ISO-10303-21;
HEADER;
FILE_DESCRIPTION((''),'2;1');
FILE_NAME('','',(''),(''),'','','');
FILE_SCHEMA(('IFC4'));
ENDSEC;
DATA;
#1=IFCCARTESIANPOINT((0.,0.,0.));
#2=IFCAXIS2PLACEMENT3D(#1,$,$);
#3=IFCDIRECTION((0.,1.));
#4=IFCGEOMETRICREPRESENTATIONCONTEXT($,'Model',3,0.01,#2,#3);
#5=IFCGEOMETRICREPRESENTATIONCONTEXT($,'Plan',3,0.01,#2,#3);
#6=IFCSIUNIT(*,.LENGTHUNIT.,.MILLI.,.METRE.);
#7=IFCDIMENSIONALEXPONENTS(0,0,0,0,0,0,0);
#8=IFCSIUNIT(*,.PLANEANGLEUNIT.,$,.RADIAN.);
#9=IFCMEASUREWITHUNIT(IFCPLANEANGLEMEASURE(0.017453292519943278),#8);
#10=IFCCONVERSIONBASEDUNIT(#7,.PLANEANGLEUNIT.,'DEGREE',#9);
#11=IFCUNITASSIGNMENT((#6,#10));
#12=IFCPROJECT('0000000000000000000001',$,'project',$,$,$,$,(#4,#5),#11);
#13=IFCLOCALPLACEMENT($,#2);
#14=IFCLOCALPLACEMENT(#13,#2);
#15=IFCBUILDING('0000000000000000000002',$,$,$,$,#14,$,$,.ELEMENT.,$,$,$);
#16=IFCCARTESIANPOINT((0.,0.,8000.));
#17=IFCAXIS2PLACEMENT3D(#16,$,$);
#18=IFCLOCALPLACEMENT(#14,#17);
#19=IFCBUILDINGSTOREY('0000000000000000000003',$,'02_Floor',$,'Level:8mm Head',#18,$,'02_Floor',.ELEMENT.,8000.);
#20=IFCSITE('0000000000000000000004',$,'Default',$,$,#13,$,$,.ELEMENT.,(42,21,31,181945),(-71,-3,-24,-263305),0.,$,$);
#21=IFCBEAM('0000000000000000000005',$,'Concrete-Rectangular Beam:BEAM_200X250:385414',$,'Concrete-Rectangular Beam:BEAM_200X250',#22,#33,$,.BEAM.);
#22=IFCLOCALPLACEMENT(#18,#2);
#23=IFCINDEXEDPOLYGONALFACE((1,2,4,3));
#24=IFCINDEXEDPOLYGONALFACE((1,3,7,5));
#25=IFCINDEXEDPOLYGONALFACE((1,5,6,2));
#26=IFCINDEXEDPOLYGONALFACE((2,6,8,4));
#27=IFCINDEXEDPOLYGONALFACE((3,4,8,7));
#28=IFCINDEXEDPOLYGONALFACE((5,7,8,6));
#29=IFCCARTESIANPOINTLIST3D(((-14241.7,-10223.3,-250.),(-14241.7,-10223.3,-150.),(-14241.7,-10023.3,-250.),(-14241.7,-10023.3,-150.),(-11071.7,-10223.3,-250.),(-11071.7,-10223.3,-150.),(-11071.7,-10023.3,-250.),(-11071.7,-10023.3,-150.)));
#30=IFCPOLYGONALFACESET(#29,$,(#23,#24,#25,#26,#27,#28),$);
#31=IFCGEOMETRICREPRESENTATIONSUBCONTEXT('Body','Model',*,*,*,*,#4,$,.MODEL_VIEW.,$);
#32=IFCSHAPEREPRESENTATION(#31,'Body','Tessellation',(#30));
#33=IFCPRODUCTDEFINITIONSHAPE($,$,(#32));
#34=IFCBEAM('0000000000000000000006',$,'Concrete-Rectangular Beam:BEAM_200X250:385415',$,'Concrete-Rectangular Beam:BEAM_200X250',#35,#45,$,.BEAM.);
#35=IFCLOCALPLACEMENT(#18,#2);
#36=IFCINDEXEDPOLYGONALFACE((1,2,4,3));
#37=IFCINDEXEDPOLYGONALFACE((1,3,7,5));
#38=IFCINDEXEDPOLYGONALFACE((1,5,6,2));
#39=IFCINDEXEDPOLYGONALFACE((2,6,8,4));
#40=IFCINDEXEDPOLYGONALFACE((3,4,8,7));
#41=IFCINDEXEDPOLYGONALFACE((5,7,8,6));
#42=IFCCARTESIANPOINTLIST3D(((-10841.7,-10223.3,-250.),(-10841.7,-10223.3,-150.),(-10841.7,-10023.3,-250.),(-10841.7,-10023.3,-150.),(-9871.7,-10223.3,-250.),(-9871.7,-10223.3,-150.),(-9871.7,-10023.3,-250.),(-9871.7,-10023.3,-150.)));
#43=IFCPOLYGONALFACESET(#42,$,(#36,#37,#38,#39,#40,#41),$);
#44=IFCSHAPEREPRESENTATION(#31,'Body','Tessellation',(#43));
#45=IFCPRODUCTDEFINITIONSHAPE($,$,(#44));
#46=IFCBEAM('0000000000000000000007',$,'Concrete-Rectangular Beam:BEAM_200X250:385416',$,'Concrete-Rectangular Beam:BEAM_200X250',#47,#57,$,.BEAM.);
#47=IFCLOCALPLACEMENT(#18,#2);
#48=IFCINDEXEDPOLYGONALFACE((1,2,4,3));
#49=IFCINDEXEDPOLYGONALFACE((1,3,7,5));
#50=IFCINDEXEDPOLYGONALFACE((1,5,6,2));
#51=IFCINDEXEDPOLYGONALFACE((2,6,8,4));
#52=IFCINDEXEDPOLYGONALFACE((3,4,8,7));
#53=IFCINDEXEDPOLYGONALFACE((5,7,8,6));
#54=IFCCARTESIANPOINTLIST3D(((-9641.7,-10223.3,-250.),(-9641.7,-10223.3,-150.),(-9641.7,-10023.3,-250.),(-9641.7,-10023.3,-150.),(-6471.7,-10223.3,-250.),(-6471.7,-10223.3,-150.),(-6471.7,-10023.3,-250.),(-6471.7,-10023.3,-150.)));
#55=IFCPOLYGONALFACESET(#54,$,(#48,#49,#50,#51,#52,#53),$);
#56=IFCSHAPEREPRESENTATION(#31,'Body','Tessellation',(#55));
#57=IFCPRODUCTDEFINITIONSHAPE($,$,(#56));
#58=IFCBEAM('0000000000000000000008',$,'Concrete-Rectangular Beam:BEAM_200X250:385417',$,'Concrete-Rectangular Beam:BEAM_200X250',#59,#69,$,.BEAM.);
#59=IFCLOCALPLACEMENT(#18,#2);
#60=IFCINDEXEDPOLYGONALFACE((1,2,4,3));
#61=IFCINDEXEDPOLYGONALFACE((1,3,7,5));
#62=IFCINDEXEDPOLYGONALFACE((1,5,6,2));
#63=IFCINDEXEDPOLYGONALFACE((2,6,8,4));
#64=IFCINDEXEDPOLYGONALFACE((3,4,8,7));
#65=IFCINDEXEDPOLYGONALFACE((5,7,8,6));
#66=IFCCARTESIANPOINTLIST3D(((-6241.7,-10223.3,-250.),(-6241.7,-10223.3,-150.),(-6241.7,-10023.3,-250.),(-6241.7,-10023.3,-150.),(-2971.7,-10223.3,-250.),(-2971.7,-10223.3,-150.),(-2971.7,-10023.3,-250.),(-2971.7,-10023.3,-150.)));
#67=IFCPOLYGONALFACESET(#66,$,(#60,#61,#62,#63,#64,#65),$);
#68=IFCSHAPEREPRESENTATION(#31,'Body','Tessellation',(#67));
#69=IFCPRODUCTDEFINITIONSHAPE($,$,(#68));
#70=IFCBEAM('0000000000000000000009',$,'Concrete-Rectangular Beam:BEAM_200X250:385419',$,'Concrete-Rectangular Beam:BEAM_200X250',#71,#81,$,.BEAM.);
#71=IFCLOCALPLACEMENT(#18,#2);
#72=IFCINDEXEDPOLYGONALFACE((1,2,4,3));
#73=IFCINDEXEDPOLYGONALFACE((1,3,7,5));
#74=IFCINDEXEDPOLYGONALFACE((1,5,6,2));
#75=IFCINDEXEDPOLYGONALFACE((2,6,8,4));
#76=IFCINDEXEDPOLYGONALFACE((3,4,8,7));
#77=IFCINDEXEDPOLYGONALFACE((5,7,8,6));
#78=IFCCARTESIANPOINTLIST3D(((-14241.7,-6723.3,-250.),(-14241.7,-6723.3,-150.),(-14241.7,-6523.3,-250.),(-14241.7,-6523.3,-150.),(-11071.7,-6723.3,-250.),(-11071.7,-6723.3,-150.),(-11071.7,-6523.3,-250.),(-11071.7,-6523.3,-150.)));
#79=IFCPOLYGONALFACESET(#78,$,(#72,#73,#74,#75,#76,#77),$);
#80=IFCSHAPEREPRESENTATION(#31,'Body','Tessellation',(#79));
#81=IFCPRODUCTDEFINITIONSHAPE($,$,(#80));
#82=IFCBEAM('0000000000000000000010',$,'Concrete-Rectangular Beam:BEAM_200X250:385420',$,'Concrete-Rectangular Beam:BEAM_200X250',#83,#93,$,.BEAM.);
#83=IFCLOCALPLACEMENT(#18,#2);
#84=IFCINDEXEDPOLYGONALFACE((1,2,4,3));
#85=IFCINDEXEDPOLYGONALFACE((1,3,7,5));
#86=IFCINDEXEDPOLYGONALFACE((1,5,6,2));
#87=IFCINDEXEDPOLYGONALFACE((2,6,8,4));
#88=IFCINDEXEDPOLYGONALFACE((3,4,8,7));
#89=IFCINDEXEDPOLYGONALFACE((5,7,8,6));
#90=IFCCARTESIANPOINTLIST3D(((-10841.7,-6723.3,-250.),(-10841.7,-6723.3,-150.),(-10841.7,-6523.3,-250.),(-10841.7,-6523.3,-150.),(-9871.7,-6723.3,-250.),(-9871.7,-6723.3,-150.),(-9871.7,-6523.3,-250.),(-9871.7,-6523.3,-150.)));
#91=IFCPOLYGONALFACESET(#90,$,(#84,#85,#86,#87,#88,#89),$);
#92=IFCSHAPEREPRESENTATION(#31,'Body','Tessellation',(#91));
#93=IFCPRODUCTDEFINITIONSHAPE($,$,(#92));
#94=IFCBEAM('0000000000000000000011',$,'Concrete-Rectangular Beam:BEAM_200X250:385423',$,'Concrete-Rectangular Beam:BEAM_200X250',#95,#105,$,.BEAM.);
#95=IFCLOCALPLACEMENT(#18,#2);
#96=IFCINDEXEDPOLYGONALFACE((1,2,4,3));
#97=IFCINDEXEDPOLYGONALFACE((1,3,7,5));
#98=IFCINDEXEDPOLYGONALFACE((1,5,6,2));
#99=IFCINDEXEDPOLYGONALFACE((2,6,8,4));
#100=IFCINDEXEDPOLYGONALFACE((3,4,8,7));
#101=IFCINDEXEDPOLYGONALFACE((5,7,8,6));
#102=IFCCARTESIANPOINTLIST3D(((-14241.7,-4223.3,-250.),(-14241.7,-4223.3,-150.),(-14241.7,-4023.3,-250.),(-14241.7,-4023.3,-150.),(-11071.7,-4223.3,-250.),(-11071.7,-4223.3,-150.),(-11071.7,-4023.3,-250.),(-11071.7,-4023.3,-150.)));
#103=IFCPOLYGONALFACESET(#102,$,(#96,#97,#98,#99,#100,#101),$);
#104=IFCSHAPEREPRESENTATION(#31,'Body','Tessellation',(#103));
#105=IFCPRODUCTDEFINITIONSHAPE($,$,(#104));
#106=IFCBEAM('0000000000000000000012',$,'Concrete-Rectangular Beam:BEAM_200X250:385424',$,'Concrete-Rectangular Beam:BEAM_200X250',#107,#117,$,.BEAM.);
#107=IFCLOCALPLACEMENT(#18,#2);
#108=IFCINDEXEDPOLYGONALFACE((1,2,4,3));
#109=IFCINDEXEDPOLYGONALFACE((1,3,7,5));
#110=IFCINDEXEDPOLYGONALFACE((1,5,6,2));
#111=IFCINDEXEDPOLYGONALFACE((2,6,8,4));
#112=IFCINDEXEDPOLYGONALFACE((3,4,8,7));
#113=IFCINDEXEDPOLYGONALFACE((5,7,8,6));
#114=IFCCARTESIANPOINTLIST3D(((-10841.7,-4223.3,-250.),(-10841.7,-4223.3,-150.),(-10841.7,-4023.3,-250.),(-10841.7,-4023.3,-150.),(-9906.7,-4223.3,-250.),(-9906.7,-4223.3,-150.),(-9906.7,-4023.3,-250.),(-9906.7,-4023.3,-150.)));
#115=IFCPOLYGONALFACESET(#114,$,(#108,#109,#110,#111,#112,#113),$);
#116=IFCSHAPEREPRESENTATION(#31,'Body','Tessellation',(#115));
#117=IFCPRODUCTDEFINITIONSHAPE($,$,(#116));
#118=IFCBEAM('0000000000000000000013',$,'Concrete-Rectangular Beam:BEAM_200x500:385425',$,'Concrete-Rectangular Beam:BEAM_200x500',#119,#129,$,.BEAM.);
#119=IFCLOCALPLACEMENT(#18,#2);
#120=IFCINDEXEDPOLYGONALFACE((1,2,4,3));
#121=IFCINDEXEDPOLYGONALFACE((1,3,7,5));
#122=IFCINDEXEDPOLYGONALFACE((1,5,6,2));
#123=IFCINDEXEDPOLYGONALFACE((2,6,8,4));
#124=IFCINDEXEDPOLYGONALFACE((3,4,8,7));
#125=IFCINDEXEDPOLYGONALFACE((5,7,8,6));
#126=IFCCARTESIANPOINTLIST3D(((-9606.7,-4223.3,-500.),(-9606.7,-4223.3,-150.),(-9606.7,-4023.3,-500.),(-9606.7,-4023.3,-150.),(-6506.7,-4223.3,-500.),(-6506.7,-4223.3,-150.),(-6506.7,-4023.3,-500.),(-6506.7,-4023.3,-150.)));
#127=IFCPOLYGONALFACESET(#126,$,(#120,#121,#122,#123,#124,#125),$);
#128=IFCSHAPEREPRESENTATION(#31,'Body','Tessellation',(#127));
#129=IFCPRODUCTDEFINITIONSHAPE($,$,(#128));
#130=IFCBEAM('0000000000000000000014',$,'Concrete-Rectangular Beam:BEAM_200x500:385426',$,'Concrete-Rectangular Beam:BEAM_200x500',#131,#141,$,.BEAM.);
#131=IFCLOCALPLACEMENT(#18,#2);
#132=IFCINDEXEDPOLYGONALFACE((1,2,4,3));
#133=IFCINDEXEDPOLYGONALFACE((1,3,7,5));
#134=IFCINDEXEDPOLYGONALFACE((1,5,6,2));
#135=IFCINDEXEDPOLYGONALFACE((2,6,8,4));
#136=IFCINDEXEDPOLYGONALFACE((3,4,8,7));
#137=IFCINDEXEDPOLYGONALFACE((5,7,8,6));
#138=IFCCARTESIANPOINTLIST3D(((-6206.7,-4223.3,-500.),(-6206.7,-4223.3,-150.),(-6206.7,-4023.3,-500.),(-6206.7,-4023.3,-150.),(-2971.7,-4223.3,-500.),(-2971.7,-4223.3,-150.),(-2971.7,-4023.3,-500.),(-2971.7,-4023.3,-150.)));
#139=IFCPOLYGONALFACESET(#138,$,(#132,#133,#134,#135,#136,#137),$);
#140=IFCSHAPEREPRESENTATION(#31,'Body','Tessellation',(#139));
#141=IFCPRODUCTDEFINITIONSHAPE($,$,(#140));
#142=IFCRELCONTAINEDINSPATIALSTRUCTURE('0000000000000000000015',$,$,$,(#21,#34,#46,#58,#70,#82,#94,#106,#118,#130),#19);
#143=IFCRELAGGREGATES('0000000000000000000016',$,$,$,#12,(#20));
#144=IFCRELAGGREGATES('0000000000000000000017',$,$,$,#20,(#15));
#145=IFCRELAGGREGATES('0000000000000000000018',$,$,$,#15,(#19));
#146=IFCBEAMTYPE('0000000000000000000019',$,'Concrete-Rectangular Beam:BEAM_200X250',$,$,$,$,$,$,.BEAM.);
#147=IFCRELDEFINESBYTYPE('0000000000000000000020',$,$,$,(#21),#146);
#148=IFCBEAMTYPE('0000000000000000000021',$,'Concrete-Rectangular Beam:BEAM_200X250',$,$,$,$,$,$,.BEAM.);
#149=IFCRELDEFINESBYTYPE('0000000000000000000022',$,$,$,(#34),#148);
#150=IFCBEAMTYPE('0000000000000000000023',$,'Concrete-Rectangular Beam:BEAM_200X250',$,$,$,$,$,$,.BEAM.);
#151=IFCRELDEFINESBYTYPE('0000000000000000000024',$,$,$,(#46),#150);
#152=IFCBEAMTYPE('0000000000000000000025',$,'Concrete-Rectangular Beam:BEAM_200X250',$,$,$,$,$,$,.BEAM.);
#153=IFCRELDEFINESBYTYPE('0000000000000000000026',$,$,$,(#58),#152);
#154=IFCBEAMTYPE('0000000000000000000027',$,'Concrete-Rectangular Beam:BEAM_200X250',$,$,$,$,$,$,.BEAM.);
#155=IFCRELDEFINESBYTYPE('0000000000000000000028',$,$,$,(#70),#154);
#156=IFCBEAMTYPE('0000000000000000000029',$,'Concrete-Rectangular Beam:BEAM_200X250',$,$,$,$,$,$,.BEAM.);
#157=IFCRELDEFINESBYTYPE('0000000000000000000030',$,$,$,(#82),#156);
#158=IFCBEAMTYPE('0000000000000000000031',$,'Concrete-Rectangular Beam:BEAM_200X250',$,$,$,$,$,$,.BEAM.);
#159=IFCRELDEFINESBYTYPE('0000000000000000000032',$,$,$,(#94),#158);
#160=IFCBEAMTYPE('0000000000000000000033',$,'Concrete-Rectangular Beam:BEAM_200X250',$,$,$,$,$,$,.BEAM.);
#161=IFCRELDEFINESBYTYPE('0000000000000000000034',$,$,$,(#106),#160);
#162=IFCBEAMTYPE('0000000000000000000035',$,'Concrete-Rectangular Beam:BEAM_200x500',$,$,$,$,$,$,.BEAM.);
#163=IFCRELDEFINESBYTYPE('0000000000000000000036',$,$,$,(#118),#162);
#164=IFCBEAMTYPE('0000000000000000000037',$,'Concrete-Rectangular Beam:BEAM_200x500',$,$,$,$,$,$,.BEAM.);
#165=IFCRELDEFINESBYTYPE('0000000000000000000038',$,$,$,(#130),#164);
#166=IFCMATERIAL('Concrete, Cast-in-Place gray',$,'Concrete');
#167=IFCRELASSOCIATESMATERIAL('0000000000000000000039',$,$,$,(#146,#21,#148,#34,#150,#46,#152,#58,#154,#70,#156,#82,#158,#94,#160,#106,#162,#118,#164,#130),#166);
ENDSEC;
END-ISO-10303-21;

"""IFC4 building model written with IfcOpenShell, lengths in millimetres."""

from ifc_helpers import new_model, entity, si_unit, converted_unit, direction, frame, origin, place, context, subcontext, project, spatial, indexed_curve, outline, extrude, source, transform, mapped, material, type_object, type_shapes, element, save


model = new_model("IFC4")

# Units and contexts
model_context = context("Model", 3, precision=0.01, world=origin(), true_north=direction((0.0, 1.0)))
plan_context = context("Plan", 3, precision=0.01, world=origin(), true_north=direction((0.0, 1.0)))
body_context = subcontext(model_context, "Body", "Model", "MODEL_VIEW")
ifc_project = project(units=[si_unit("LENGTHUNIT", "METRE", prefix="MILLI"), converted_unit("PLANEANGLEUNIT", "DEGREE", entity("IfcPlaneAngleMeasure", 0.017453292519943278), si_unit("PLANEANGLEUNIT", "RADIAN"), dimensions=[0, 0, 0, 0, 0, 0, 0])], contexts=[model_context, plan_context])

# Site, building, storey
site_placement = place(None, origin())
site = spatial("IfcSite", under=ifc_project, at=site_placement, Name="Default", CompositionType="ELEMENT", RefLatitude=(42, 21, 31, 181945), RefLongitude=(-71, -3, -24, -263305), RefElevation=0.0)
building_placement = place(site_placement, origin())
building = spatial("IfcBuilding", under=site, at=building_placement, CompositionType="ELEMENT")
storey_placement = place(building_placement, frame((0.0, 0.0, 8000.0)))
storey = spatial("IfcBuildingStorey", under=building, at=storey_placement, Name="02_Floor", ObjectType="Level:8mm Head", LongName="02_Floor", CompositionType="ELEMENT", Elevation=8000.0)

# Beams
ifc_material_1 = material(Name="Concrete, Cast-in-Place gray", Category="Concrete")
beam_type_1 = type_object("IfcBeamType", Name="Concrete-Rectangular Beam:BEAM_200X250", PredefinedType="BEAM", material=ifc_material_1)
shared_shape_1 = source(origin(), body_context, "Body", "SweptSolid", [
    extrude(outline(indexed_curve([(-50.0, -100.0), (50.0, -100.0), (50.0, 100.0), (-50.0, 100.0), (-50.0, -100.0)], self_intersect=False)), frame((-14241.7, -10123.3, 7800.0), z_axis=(1.0, 0.0, 0.0), x_axis=(0.0, 0.0, -1.0)), (0.0, 0.0, 1.0), 3170.0),
])
type_shapes(beam_type_1, [shared_shape_1])
beam_1_placement = place(storey_placement, frame((0.0, 0.0, -8000.0)))
element("IfcBeam", 1, at=beam_1_placement, inside=storey, type_object=beam_type_1, material=ifc_material_1, Name="Concrete-Rectangular Beam:BEAM_200X250:385414", ObjectType="Concrete-Rectangular Beam:BEAM_200X250", PredefinedType="BEAM", context=body_context, shape_type="MappedRepresentation", body=[
    mapped(shared_shape_1, transform((0.0, 0.0, 0.0), scale=1.0)),
])
beam_type_2 = type_object("IfcBeamType", Name="Concrete-Rectangular Beam:BEAM_200X250", PredefinedType="BEAM", material=ifc_material_1)
shared_shape_2 = source(origin(), body_context, "Body", "SweptSolid", [
    extrude(outline(indexed_curve([(-50.0, -100.0), (50.0, -100.0), (50.0, 100.0), (-50.0, 100.0), (-50.0, -100.0)], self_intersect=False)), frame((-10841.7, -10123.3, 7800.0), z_axis=(1.0, 0.0, 0.0), x_axis=(0.0, 0.0, -1.0)), (0.0, 0.0, 1.0), 970.0),
])
type_shapes(beam_type_2, [shared_shape_2])
beam_2_placement = place(storey_placement, frame((0.0, 0.0, -8000.0)))
element("IfcBeam", 2, at=beam_2_placement, inside=storey, type_object=beam_type_2, material=ifc_material_1, Name="Concrete-Rectangular Beam:BEAM_200X250:385415", ObjectType="Concrete-Rectangular Beam:BEAM_200X250", PredefinedType="BEAM", context=body_context, shape_type="MappedRepresentation", body=[
    mapped(shared_shape_2, transform((0.0, 0.0, 0.0), scale=1.0)),
])
beam_type_3 = type_object("IfcBeamType", Name="Concrete-Rectangular Beam:BEAM_200X250", PredefinedType="BEAM", material=ifc_material_1)
shared_shape_3 = source(origin(), body_context, "Body", "SweptSolid", [
    extrude(outline(indexed_curve([(-50.0, -100.0), (50.0, -100.0), (50.0, 100.0), (-50.0, 100.0), (-50.0, -100.0)], self_intersect=False)), frame((-9641.7, -10123.3, 7800.0), z_axis=(1.0, 0.0, 0.0), x_axis=(0.0, 0.0, -1.0)), (0.0, 0.0, 1.0), 3170.0),
])
type_shapes(beam_type_3, [shared_shape_3])
beam_3_placement = place(storey_placement, frame((0.0, 0.0, -8000.0)))
element("IfcBeam", 3, at=beam_3_placement, inside=storey, type_object=beam_type_3, material=ifc_material_1, Name="Concrete-Rectangular Beam:BEAM_200X250:385416", ObjectType="Concrete-Rectangular Beam:BEAM_200X250", PredefinedType="BEAM", context=body_context, shape_type="MappedRepresentation", body=[
    mapped(shared_shape_3, transform((0.0, 0.0, 0.0), scale=1.0)),
])
beam_type_4 = type_object("IfcBeamType", Name="Concrete-Rectangular Beam:BEAM_200X250", PredefinedType="BEAM", material=ifc_material_1)
shared_shape_4 = source(origin(), body_context, "Body", "SweptSolid", [
    extrude(outline(indexed_curve([(-50.0, -100.0), (50.0, -100.0), (50.0, 100.0), (-50.0, 100.0), (-50.0, -100.0)], self_intersect=False)), frame((-6241.7, -10123.3, 7800.0), z_axis=(1.0, 0.0, 0.0), x_axis=(0.0, 0.0, -1.0)), (0.0, 0.0, 1.0), 3270.0),
])
type_shapes(beam_type_4, [shared_shape_4])
beam_4_placement = place(storey_placement, frame((0.0, 0.0, -8000.0)))
element("IfcBeam", 4, at=beam_4_placement, inside=storey, type_object=beam_type_4, material=ifc_material_1, Name="Concrete-Rectangular Beam:BEAM_200X250:385417", ObjectType="Concrete-Rectangular Beam:BEAM_200X250", PredefinedType="BEAM", context=body_context, shape_type="MappedRepresentation", body=[
    mapped(shared_shape_4, transform((0.0, 0.0, 0.0), scale=1.0)),
])
beam_type_5 = type_object("IfcBeamType", Name="Concrete-Rectangular Beam:BEAM_200X250", PredefinedType="BEAM", material=ifc_material_1)
shared_shape_5 = source(origin(), body_context, "Body", "SweptSolid", [
    extrude(outline(indexed_curve([(-50.0, -100.0), (50.0, -100.0), (50.0, 100.0), (-50.0, 100.0), (-50.0, -100.0)], self_intersect=False)), frame((-14241.7, -6623.3, 7800.0), z_axis=(1.0, 0.0, 0.0), x_axis=(0.0, 0.0, -1.0)), (0.0, 0.0, 1.0), 3170.0),
])
type_shapes(beam_type_5, [shared_shape_5])
beam_5_placement = place(storey_placement, frame((0.0, 0.0, -8000.0)))
element("IfcBeam", 5, at=beam_5_placement, inside=storey, type_object=beam_type_5, material=ifc_material_1, Name="Concrete-Rectangular Beam:BEAM_200X250:385419", ObjectType="Concrete-Rectangular Beam:BEAM_200X250", PredefinedType="BEAM", context=body_context, shape_type="MappedRepresentation", body=[
    mapped(shared_shape_5, transform((0.0, 0.0, 0.0), scale=1.0)),
])
beam_type_6 = type_object("IfcBeamType", Name="Concrete-Rectangular Beam:BEAM_200X250", PredefinedType="BEAM", material=ifc_material_1)
shared_shape_6 = source(origin(), body_context, "Body", "SweptSolid", [
    extrude(outline(indexed_curve([(-50.0, -100.0), (50.0, -100.0), (50.0, 100.0), (-50.0, 100.0), (-50.0, -100.0)], self_intersect=False)), frame((-10841.7, -6623.3, 7800.0), z_axis=(1.0, 0.0, 0.0), x_axis=(0.0, 0.0, -1.0)), (0.0, 0.0, 1.0), 970.0),
])
type_shapes(beam_type_6, [shared_shape_6])
beam_6_placement = place(storey_placement, frame((0.0, 0.0, -8000.0)))
element("IfcBeam", 6, at=beam_6_placement, inside=storey, type_object=beam_type_6, material=ifc_material_1, Name="Concrete-Rectangular Beam:BEAM_200X250:385420", ObjectType="Concrete-Rectangular Beam:BEAM_200X250", PredefinedType="BEAM", context=body_context, shape_type="MappedRepresentation", body=[
    mapped(shared_shape_6, transform((0.0, 0.0, 0.0), scale=1.0)),
])
beam_type_7 = type_object("IfcBeamType", Name="Concrete-Rectangular Beam:BEAM_200X250", PredefinedType="BEAM", material=ifc_material_1)
shared_shape_7 = source(origin(), body_context, "Body", "SweptSolid", [
    extrude(outline(indexed_curve([(-50.0, -100.0), (50.0, -100.0), (50.0, 100.0), (-50.0, 100.0), (-50.0, -100.0)], self_intersect=False)), frame((-14241.7, -4123.3, 7800.0), z_axis=(1.0, 0.0, 0.0), x_axis=(0.0, 0.0, -1.0)), (0.0, 0.0, 1.0), 3170.0),
])
type_shapes(beam_type_7, [shared_shape_7])
beam_7_placement = place(storey_placement, frame((0.0, 0.0, -8000.0)))
element("IfcBeam", 7, at=beam_7_placement, inside=storey, type_object=beam_type_7, material=ifc_material_1, Name="Concrete-Rectangular Beam:BEAM_200X250:385423", ObjectType="Concrete-Rectangular Beam:BEAM_200X250", PredefinedType="BEAM", context=body_context, shape_type="MappedRepresentation", body=[
    mapped(shared_shape_7, transform((0.0, 0.0, 0.0), scale=1.0)),
])
beam_type_8 = type_object("IfcBeamType", Name="Concrete-Rectangular Beam:BEAM_200X250", PredefinedType="BEAM", material=ifc_material_1)
shared_shape_8 = source(origin(), body_context, "Body", "SweptSolid", [
    extrude(outline(indexed_curve([(-50.0, -100.0), (50.0, -100.0), (50.0, 100.0), (-50.0, 100.0), (-50.0, -100.0)], self_intersect=False)), frame((-10841.7, -4123.3, 7800.0), z_axis=(1.0, 0.0, 0.0), x_axis=(0.0, 0.0, -1.0)), (0.0, 0.0, 1.0), 935.0),
])
type_shapes(beam_type_8, [shared_shape_8])
beam_8_placement = place(storey_placement, frame((0.0, 0.0, -8000.0)))
element("IfcBeam", 8, at=beam_8_placement, inside=storey, type_object=beam_type_8, material=ifc_material_1, Name="Concrete-Rectangular Beam:BEAM_200X250:385424", ObjectType="Concrete-Rectangular Beam:BEAM_200X250", PredefinedType="BEAM", context=body_context, shape_type="MappedRepresentation", body=[
    mapped(shared_shape_8, transform((0.0, 0.0, 0.0), scale=1.0)),
])
beam_type_9 = type_object("IfcBeamType", Name="Concrete-Rectangular Beam:BEAM_200x500", PredefinedType="BEAM", material=ifc_material_1)
shared_shape_9 = source(origin(), body_context, "Body", "SweptSolid", [
    extrude(outline(indexed_curve([(-175.0, -100.0), (175.0, -100.0), (175.0, 100.0), (-175.0, 100.0), (-175.0, -100.0)], self_intersect=False)), frame((-9606.7, -4123.3, 7675.0), z_axis=(1.0, 0.0, 0.0), x_axis=(0.0, 0.0, -1.0)), (0.0, 0.0, 1.0), 3100.0),
])
type_shapes(beam_type_9, [shared_shape_9])
beam_9_placement = place(storey_placement, frame((0.0, 0.0, -8000.0)))
element("IfcBeam", 9, at=beam_9_placement, inside=storey, type_object=beam_type_9, material=ifc_material_1, Name="Concrete-Rectangular Beam:BEAM_200x500:385425", ObjectType="Concrete-Rectangular Beam:BEAM_200x500", PredefinedType="BEAM", context=body_context, shape_type="MappedRepresentation", body=[
    mapped(shared_shape_9, transform((0.0, 0.0, 0.0), scale=1.0)),
])
beam_type_10 = type_object("IfcBeamType", Name="Concrete-Rectangular Beam:BEAM_200x500", PredefinedType="BEAM", material=ifc_material_1)
shared_shape_10 = source(origin(), body_context, "Body", "SweptSolid", [
    extrude(outline(indexed_curve([(-175.0, -100.0), (175.0, -100.0), (175.0, 100.0), (-175.0, 100.0), (-175.0, -100.0)], self_intersect=False)), frame((-6206.7, -4123.3, 7675.0), z_axis=(1.0, 0.0, 0.0), x_axis=(0.0, 0.0, -1.0)), (0.0, 0.0, 1.0), 3235.0),
])
type_shapes(beam_type_10, [shared_shape_10])
beam_10_placement = place(storey_placement, frame((0.0, 0.0, -8000.0)))
element("IfcBeam", 10, at=beam_10_placement, inside=storey, type_object=beam_type_10, material=ifc_material_1, Name="Concrete-Rectangular Beam:BEAM_200x500:385426", ObjectType="Concrete-Rectangular Beam:BEAM_200x500", PredefinedType="BEAM", context=body_context, shape_type="MappedRepresentation", body=[
    mapped(shared_shape_10, transform((0.0, 0.0, 0.0), scale=1.0)),
])

save(model, "model.ifc")
